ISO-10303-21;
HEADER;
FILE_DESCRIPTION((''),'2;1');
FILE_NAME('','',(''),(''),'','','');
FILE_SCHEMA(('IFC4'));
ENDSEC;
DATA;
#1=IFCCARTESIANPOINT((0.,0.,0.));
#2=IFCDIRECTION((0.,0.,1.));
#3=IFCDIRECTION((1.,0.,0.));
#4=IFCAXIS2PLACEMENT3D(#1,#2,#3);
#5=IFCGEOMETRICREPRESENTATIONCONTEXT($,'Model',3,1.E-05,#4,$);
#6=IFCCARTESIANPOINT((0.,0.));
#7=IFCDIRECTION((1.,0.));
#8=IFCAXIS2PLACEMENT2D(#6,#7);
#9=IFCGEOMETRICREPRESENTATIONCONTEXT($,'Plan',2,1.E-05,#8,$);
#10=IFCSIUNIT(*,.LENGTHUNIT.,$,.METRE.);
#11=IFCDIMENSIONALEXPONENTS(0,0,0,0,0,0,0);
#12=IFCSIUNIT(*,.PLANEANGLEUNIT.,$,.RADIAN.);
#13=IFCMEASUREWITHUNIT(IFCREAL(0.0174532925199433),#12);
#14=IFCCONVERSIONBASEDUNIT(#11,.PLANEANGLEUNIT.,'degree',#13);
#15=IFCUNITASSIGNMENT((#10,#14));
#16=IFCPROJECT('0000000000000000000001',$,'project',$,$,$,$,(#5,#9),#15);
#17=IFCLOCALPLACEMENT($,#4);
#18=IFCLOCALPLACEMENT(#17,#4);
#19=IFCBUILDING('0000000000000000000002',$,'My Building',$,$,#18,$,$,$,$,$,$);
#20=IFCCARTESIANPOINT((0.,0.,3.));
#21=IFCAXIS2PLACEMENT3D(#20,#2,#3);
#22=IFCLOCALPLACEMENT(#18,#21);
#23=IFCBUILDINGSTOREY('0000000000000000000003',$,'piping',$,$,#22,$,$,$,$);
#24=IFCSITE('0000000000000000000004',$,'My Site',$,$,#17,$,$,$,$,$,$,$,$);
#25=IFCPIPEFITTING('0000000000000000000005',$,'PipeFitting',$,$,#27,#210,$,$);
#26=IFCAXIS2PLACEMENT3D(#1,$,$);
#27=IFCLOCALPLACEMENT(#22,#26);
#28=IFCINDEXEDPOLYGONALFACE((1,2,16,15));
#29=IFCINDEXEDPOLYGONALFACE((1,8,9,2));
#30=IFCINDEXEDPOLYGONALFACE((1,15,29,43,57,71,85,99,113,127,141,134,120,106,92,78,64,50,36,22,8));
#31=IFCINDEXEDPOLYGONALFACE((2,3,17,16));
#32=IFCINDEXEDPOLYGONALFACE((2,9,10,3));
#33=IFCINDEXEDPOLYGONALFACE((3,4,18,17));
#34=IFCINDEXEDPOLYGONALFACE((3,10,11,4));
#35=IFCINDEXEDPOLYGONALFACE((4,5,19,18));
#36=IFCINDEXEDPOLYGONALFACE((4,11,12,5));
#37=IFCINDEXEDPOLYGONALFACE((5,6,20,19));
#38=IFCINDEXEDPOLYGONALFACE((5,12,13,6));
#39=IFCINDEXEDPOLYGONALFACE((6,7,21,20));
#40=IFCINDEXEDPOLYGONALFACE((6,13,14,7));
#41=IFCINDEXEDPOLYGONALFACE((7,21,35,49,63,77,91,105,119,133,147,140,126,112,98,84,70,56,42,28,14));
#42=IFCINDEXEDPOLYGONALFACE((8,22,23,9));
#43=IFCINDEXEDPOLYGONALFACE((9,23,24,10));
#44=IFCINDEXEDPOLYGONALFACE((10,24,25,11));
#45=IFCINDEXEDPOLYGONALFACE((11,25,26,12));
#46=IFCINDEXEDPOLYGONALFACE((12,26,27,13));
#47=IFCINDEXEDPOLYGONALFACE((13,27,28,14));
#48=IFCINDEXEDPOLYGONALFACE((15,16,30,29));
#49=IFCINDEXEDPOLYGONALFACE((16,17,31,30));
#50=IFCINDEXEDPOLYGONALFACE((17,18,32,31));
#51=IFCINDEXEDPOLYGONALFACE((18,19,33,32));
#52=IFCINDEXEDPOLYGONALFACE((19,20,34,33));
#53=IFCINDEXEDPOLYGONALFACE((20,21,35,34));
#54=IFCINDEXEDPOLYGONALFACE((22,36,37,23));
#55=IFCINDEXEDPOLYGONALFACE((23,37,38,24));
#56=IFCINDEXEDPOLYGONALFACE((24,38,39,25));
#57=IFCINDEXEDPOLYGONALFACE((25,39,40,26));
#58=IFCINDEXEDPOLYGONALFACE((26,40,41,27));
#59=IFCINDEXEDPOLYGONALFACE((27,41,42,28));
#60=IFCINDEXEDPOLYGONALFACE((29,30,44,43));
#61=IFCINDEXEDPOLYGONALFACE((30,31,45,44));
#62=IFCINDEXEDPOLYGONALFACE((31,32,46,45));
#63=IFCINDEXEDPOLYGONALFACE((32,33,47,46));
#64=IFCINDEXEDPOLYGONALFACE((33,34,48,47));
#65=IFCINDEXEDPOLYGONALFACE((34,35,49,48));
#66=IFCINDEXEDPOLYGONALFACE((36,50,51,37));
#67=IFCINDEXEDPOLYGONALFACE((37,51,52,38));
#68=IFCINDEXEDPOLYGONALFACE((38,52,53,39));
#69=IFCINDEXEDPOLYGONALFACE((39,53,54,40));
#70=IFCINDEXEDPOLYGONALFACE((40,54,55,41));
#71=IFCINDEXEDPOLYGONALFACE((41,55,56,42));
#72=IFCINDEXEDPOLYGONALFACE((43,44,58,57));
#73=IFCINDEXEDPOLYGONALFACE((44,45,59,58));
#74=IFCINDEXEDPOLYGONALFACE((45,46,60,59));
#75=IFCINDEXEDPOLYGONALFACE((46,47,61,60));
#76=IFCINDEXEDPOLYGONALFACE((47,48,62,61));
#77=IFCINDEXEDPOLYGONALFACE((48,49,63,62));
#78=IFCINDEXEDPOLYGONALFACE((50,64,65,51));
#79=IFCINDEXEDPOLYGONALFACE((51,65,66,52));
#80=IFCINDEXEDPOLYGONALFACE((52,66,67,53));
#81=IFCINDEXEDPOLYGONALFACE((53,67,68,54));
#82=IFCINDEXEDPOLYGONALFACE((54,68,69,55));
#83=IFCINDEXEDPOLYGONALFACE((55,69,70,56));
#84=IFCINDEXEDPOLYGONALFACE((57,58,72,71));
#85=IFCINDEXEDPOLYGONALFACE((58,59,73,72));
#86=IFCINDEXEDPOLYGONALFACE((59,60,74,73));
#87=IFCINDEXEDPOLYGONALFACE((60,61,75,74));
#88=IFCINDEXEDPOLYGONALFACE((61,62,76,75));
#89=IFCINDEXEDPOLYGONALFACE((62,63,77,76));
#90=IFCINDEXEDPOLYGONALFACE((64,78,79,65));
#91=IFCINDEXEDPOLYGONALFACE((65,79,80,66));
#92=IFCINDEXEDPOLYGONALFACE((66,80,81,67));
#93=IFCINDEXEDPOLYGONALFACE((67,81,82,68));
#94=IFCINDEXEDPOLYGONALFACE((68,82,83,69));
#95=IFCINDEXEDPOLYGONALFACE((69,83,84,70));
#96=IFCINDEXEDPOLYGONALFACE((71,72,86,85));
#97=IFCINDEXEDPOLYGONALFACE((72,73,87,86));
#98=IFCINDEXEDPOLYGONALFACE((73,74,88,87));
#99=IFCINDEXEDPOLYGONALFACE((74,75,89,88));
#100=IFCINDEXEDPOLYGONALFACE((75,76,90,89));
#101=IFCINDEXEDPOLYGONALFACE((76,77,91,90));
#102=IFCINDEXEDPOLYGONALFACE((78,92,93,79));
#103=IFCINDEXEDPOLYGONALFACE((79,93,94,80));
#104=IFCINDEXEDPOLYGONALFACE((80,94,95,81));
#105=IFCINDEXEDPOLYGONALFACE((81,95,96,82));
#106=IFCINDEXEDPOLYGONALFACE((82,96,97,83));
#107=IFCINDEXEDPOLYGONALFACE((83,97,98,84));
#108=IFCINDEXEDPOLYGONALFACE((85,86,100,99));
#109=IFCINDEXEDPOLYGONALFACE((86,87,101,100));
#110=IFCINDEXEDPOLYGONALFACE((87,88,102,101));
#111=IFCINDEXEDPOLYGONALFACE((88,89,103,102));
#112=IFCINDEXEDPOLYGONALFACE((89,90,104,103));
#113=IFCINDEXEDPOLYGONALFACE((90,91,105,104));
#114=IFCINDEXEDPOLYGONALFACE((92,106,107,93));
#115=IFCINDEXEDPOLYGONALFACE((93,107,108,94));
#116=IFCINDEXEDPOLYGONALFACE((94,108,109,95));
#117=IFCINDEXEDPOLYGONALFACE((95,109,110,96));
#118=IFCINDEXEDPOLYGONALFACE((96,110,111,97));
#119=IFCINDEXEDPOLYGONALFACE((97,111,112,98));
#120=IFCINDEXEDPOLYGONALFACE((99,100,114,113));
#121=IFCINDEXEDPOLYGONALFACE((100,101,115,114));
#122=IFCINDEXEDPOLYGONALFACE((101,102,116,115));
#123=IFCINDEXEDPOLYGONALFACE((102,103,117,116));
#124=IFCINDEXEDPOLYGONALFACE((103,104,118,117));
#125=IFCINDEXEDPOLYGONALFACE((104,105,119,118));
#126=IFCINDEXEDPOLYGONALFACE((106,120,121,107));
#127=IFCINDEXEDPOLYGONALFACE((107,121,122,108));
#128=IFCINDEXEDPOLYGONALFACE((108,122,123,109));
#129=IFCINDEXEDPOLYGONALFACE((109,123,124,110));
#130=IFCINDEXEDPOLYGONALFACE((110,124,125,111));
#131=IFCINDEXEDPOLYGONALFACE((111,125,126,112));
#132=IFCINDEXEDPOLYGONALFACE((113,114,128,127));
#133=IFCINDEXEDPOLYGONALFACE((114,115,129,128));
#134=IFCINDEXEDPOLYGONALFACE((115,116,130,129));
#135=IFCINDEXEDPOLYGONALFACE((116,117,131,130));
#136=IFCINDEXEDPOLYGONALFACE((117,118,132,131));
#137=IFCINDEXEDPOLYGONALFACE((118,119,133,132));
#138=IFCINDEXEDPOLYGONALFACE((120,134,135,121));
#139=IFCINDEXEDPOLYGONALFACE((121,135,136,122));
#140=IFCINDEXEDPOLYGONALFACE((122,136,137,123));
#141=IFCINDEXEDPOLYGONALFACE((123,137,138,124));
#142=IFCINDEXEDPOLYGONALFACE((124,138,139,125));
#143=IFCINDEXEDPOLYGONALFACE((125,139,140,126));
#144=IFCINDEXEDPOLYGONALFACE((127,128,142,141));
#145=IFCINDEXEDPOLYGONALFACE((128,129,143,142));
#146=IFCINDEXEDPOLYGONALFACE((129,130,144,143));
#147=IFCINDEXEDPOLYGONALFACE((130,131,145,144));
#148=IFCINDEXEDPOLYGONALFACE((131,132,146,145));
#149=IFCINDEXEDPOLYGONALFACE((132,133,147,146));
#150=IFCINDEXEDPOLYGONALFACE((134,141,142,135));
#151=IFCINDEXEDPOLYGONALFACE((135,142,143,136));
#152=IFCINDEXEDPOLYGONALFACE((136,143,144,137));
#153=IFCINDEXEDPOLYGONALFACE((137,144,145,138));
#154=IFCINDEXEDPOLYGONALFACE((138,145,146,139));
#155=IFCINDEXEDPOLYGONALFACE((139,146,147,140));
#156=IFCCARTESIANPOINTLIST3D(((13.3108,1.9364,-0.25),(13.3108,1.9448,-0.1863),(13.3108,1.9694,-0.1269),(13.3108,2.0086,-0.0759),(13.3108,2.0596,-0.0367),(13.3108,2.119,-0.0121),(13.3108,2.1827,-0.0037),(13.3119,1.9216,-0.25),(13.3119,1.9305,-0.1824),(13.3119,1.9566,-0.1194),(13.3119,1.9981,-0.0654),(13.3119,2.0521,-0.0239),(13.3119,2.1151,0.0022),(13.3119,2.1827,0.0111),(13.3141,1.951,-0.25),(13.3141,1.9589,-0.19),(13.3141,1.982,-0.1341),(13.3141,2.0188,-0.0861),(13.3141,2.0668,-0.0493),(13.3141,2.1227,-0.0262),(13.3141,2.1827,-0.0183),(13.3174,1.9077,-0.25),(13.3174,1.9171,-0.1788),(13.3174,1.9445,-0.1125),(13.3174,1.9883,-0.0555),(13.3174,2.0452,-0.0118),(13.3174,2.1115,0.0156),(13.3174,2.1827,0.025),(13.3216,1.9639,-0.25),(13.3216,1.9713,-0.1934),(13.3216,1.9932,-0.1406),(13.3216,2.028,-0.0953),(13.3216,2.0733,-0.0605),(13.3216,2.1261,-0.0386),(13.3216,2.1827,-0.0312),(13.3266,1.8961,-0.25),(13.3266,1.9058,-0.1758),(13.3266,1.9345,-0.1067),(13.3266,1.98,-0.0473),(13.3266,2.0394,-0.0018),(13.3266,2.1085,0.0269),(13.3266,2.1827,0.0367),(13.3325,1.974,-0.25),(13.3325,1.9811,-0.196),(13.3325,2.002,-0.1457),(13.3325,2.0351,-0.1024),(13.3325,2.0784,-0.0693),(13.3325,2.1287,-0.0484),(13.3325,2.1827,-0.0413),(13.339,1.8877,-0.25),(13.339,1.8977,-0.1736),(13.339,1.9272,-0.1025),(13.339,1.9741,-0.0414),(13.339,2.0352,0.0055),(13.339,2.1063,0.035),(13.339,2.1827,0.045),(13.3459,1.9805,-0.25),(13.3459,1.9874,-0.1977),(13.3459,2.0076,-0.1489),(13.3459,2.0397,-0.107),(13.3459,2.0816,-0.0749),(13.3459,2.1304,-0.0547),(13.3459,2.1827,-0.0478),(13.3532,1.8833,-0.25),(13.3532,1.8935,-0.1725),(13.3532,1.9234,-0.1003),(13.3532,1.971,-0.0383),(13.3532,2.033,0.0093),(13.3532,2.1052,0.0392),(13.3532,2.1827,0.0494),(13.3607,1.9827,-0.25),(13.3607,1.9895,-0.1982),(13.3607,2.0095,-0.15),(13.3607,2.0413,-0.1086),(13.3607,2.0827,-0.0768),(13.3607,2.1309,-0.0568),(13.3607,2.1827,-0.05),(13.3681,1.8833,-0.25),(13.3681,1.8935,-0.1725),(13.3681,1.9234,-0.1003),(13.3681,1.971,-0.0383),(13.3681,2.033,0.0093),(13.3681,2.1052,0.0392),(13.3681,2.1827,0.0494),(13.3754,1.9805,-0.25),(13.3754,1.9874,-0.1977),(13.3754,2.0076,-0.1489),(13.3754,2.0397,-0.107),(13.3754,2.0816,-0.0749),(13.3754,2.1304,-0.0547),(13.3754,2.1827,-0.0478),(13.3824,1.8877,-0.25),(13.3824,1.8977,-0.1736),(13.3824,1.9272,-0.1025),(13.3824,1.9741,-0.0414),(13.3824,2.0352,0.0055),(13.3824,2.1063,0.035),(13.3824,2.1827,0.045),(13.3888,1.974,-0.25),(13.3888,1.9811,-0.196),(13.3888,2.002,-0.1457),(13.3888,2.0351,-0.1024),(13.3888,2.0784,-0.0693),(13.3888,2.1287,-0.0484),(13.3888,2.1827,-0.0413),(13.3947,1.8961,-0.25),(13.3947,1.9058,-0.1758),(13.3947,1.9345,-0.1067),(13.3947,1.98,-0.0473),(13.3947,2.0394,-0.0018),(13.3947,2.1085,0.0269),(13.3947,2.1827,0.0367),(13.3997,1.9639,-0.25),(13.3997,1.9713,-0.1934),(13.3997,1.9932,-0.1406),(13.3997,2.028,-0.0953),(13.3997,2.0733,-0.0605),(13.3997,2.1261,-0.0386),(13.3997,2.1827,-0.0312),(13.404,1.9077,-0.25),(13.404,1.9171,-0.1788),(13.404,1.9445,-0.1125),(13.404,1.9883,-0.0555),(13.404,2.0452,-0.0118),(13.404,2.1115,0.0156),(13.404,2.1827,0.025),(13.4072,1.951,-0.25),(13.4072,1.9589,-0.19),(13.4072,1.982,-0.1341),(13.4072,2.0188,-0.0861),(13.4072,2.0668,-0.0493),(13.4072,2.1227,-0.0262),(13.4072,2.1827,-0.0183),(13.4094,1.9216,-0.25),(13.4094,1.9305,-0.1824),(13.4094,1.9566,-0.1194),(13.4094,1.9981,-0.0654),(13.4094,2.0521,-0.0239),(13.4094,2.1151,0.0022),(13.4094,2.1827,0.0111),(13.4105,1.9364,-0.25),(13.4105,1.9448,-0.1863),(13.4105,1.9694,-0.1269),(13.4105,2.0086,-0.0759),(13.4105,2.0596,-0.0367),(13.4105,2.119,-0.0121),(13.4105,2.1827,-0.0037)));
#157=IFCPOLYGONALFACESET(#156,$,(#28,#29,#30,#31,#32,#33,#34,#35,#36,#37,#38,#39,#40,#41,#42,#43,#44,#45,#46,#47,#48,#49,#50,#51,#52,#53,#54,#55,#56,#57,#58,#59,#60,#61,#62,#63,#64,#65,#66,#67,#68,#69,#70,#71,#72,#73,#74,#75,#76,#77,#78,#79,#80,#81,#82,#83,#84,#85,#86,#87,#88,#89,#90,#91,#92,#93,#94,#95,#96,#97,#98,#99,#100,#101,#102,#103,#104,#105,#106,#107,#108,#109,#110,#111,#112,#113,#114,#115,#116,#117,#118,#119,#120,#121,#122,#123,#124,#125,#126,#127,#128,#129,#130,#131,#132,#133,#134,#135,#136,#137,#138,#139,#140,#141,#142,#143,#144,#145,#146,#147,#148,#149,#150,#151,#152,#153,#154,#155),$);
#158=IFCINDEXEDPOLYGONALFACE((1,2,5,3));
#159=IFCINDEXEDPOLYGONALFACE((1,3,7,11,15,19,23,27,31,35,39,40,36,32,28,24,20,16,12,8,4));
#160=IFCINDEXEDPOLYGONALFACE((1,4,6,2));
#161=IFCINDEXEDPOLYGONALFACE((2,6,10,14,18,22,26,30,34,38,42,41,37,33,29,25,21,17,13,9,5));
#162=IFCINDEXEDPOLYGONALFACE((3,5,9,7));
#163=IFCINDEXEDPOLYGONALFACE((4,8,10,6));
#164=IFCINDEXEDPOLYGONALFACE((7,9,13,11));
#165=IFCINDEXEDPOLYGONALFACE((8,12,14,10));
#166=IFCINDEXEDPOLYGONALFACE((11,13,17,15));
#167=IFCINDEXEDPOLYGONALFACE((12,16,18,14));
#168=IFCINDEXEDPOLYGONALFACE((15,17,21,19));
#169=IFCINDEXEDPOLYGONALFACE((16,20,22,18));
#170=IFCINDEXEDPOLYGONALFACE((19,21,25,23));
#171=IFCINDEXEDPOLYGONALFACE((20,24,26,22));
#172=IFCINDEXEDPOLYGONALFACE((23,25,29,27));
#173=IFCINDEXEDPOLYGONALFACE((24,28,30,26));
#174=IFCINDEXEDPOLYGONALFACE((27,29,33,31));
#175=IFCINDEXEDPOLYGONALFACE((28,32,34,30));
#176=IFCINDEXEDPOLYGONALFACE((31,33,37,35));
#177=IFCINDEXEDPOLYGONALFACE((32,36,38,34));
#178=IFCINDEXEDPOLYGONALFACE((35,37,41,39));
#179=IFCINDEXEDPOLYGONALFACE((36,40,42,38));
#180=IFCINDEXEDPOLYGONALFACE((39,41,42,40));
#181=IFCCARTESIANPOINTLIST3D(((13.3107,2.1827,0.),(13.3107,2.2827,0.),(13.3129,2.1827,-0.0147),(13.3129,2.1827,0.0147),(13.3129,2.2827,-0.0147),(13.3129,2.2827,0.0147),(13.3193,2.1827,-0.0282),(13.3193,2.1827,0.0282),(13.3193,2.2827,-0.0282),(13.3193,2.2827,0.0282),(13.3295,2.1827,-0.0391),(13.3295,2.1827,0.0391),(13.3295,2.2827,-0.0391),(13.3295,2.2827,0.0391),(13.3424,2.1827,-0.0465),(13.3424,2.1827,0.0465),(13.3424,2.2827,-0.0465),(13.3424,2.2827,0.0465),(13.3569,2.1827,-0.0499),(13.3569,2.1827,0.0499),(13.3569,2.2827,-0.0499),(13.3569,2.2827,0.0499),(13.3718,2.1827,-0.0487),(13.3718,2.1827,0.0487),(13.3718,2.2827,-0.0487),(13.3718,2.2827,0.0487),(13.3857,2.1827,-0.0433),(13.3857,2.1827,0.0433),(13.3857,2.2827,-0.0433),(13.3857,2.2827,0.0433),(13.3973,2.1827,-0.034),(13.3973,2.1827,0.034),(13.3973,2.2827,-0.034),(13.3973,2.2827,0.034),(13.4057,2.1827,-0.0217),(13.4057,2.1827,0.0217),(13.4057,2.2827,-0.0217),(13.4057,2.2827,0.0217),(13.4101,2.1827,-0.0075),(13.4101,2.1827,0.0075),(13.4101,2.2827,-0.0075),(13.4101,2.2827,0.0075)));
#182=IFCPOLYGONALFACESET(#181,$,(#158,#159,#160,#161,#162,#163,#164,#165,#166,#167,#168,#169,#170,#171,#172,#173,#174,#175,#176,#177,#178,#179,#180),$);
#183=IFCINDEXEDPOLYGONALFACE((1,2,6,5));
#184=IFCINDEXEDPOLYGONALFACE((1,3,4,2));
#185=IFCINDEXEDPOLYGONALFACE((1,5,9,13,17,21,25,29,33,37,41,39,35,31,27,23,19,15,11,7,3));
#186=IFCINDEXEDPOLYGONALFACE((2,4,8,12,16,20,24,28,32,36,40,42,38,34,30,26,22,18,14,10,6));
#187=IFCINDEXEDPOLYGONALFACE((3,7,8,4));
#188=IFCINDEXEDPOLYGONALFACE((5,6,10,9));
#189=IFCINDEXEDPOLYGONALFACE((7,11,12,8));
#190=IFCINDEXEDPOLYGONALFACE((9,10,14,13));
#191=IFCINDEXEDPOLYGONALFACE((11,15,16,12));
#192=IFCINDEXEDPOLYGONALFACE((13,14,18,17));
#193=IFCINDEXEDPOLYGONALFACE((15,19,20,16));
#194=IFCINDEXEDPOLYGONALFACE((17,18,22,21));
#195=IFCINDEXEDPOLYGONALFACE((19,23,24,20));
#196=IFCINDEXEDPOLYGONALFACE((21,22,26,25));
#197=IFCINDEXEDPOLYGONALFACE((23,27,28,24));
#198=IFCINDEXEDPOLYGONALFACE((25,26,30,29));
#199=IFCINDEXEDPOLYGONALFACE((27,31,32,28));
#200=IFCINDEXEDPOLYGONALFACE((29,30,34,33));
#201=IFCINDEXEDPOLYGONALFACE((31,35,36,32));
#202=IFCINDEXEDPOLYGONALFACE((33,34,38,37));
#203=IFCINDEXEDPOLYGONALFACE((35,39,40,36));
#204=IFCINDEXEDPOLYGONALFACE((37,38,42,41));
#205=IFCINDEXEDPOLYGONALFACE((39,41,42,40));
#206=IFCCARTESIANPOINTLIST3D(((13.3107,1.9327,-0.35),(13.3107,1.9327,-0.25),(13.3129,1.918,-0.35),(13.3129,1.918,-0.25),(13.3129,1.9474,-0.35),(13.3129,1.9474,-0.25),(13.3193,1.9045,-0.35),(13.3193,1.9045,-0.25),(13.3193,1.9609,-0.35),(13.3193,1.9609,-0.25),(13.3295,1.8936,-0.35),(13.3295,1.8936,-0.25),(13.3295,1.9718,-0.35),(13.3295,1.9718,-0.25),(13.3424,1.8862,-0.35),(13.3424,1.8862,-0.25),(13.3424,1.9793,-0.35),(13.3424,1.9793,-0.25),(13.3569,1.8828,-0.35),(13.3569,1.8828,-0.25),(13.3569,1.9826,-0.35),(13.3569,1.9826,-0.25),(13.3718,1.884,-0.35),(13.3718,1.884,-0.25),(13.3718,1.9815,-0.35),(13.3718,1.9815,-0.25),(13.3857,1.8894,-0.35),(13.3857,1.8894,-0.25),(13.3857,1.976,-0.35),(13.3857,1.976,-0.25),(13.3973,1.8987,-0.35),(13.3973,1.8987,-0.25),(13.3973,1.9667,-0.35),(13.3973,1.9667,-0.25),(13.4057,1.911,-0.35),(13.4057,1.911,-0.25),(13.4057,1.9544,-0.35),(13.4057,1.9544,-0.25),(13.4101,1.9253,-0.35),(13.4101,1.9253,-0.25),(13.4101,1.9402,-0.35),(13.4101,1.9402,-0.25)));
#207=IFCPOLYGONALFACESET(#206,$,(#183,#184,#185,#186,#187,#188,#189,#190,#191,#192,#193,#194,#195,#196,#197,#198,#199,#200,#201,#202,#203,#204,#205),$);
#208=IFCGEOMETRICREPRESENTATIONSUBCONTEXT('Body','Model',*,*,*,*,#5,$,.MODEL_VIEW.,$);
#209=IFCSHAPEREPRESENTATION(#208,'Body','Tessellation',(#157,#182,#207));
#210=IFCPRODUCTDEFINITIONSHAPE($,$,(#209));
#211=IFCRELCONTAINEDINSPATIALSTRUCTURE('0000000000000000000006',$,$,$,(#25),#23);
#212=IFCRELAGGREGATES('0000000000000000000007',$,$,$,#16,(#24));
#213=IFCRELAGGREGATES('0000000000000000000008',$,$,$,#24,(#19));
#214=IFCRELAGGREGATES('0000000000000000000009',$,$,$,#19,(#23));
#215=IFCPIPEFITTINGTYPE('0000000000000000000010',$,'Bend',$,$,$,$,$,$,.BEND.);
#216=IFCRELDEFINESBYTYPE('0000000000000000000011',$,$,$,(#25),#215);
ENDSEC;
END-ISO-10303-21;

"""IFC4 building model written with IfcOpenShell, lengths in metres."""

from ifc_helpers import new_model, entity, si_unit, converted_unit, frame, origin_with_axes, origin_2d_with_axis, place, context, subcontext, project, spatial, circle, extrude, source, transform, mapped, type_object, type_shapes, element, save


model = new_model("IFC4")

# Units and contexts
model_context = context("Model", 3, precision=1e-05, world=origin_with_axes())
plan_context = context("Plan", 2, precision=1e-05, world=origin_2d_with_axis())
body_context = subcontext(model_context, "Body", "Model", "MODEL_VIEW")
ifc_project = project(units=[si_unit("LENGTHUNIT", "METRE"), converted_unit("PLANEANGLEUNIT", "degree", entity("IfcReal", 0.0174532925199433), si_unit("PLANEANGLEUNIT", "RADIAN"), dimensions=[0, 0, 0, 0, 0, 0, 0])], contexts=[model_context, plan_context])

# Site, building, storey
site_placement = place(None, origin_with_axes())
site = spatial("IfcSite", under=ifc_project, at=site_placement, Name="My Site")
building_placement = place(site_placement, origin_with_axes())
building = spatial("IfcBuilding", under=site, at=building_placement, Name="My Building")
storey_placement = place(building_placement, frame((0.0, 0.0, 3.0), z_axis=(0.0, 0.0, 1.0), x_axis=(1.0, 0.0, 0.0)))
storey = spatial("IfcBuildingStorey", under=building, at=storey_placement, Name="piping")

# Pipe fitting
pipe_fitting_type = type_object("IfcPipeFittingType", Name="Bend", PredefinedType="BEND")
shared_shape = source(origin_with_axes(), body_context, "Body", "SolidModel", [
    entity("IfcSweptDiskSolid", entity("IfcIndexedPolyCurve", entity("IfcCartesianPointList3D", [[0.0, 0.0, -0.1], [0.0, -0.0732, -0.2768], [0.0, -0.25, -0.35]]), [entity("IfcArcIndex", [1, 2, 3])]), 0.05),
    extrude(circle(Radius=0.05), origin_with_axes(), (0.0, 0.0, -1.0), 0.1),
    extrude(circle(Radius=0.05), frame((0.0, -0.25, -0.35), z_axis=(0.0, -1.0, 0.0), x_axis=(1.0, 0.0, 0.0)), (0.0, 0.0, 1.0), 0.1),
])
type_shapes(pipe_fitting_type, [shared_shape])
for number, where, z_axis, x_axis, name in (
    (1, (13.3607, 2.2827, 0.0), (0.0, 1.0, 0.0), (-1.0, 0.0, 0.0), "PipeFitting"),
):
    element("IfcPipeFitting", number, at=place(storey_placement, frame(where, z_axis=z_axis, x_axis=x_axis)), inside=storey, type_object=pipe_fitting_type, Name=name, context=body_context, shape_type="MappedRepresentation", body=[
        mapped(shared_shape, transform((0.0, 0.0, 0.0), x_axis=(1.0, 0.0, 0.0), y_axis=(0.0, 1.0, 0.0), z_axis=(0.0, 0.0, 1.0), scale=1.0)),
    ])

save(model, "model.ifc")
